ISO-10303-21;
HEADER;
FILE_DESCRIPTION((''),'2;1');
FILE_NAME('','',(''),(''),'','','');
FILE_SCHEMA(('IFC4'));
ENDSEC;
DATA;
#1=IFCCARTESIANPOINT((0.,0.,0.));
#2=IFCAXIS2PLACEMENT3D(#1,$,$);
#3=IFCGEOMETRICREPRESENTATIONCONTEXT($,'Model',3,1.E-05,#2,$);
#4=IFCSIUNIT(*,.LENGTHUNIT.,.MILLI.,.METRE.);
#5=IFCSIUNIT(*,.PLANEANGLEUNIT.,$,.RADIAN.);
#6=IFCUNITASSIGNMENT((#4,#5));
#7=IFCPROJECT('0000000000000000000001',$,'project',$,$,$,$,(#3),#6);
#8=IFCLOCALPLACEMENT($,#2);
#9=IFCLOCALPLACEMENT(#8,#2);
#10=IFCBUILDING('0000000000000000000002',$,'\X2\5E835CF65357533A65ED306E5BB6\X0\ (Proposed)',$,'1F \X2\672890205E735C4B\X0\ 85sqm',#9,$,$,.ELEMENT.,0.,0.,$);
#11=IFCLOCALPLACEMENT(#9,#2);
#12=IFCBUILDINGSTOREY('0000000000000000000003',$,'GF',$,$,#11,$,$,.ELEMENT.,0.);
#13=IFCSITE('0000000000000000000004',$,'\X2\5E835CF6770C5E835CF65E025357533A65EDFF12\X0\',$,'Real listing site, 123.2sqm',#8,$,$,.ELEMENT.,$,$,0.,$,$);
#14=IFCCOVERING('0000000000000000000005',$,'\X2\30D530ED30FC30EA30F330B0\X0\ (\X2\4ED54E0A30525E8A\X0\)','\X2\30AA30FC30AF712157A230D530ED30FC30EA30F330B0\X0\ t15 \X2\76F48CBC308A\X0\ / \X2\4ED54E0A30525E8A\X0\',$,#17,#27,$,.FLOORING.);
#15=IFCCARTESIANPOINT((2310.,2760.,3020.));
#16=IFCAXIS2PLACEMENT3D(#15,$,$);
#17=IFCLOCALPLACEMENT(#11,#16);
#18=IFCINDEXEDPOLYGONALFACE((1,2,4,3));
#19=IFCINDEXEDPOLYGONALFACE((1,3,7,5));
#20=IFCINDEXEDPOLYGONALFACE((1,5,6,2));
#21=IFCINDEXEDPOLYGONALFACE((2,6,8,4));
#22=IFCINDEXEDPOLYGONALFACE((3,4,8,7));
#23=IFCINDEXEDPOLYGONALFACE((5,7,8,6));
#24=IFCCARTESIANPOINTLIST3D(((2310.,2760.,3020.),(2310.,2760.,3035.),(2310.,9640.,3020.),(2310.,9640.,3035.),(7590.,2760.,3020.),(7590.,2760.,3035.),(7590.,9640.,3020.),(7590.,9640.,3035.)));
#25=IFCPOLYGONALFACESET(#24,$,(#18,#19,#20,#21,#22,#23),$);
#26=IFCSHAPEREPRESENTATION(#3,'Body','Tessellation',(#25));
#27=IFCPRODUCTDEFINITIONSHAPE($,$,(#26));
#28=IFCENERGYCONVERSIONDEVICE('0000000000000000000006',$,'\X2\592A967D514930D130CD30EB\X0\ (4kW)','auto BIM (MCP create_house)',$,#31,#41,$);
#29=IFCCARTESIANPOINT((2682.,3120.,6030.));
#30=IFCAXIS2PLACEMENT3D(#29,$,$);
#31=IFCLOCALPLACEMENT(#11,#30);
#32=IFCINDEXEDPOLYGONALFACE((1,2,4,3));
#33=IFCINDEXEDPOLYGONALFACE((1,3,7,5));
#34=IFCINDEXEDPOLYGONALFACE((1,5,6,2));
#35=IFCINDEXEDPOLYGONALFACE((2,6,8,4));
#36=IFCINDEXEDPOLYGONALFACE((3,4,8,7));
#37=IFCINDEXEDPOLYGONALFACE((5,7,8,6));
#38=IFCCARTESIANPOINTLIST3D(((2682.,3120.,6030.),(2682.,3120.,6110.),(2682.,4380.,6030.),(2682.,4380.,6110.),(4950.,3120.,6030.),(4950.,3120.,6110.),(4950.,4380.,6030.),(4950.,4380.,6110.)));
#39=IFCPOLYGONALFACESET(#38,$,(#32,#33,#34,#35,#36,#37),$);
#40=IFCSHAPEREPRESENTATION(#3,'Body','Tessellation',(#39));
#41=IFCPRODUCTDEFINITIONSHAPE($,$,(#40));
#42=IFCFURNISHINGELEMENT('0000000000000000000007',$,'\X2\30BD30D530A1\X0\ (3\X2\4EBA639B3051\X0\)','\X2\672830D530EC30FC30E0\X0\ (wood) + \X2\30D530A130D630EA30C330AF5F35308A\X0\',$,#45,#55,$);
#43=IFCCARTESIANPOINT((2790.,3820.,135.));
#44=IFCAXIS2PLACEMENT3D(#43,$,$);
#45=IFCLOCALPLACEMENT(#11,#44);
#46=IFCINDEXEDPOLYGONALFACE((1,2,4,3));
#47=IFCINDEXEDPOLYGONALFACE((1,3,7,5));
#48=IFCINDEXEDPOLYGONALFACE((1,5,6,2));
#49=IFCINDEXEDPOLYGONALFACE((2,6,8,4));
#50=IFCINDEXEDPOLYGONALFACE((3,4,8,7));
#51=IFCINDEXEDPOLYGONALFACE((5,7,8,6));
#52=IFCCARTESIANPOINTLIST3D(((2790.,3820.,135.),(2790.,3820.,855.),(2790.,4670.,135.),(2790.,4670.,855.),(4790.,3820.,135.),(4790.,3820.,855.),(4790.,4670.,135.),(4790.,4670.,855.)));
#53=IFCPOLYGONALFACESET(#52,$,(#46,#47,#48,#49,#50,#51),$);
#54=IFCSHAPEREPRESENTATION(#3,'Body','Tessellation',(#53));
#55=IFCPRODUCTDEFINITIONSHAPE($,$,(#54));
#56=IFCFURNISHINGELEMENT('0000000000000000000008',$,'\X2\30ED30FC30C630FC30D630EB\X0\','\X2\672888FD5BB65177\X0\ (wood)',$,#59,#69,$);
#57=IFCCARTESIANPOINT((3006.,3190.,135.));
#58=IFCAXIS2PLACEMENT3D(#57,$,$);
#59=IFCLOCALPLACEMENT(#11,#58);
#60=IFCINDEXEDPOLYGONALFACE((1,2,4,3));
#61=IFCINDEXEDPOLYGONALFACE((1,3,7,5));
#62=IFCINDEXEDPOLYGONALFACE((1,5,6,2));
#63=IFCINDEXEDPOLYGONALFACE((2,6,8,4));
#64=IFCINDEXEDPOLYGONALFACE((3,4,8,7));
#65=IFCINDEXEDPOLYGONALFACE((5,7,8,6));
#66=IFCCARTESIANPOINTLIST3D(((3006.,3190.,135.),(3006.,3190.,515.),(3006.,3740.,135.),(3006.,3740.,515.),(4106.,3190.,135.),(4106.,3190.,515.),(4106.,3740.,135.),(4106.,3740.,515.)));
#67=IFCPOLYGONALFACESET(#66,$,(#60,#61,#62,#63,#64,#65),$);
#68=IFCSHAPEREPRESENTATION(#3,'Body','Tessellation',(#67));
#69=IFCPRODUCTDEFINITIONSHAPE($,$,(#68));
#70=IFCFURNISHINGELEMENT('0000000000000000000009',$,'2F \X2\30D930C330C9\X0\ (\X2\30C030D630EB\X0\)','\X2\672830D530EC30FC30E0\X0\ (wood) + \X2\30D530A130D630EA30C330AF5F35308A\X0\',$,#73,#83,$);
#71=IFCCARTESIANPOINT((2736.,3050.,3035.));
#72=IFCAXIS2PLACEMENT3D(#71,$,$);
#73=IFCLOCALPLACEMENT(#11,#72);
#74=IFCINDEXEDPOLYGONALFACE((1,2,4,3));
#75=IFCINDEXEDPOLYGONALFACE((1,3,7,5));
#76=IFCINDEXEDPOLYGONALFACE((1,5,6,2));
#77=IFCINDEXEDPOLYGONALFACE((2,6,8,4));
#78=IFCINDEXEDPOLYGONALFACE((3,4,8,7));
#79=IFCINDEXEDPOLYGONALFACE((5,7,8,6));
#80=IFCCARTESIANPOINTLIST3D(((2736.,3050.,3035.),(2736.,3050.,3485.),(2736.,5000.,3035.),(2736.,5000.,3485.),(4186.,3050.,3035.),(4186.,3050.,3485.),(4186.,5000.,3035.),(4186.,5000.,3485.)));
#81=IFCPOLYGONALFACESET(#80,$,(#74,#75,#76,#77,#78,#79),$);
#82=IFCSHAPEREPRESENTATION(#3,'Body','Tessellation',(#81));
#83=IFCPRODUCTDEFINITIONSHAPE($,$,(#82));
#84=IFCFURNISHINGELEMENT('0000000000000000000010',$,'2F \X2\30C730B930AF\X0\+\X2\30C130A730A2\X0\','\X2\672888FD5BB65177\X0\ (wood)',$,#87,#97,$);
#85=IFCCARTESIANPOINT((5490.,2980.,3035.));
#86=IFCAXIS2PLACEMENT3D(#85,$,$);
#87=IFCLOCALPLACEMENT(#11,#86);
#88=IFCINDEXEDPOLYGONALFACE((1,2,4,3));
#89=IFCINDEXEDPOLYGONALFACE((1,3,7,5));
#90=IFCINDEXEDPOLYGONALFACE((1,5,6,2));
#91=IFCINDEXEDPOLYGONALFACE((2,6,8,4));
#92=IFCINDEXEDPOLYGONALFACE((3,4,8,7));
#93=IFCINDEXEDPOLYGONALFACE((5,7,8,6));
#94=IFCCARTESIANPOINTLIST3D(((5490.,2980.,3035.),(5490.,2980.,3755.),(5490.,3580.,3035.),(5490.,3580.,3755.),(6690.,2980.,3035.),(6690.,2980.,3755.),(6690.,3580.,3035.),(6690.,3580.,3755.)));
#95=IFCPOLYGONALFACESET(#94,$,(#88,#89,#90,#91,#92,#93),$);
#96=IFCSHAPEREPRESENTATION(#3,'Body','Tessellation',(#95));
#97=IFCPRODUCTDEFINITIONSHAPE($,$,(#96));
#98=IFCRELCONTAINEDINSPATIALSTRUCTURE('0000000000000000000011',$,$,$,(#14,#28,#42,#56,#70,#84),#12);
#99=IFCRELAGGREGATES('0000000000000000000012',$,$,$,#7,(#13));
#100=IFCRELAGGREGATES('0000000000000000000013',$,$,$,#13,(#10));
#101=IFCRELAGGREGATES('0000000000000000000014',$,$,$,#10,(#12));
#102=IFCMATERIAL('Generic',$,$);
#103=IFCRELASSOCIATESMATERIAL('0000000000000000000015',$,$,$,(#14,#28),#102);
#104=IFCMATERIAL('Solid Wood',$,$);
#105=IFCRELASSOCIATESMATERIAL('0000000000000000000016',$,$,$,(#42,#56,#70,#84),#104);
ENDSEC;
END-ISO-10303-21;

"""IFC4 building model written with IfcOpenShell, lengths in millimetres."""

from ifc_helpers import new_model, si_unit, frame, frame_2d, origin, place, context, project, spatial, rectangle, extrude, material, element, save


model = new_model("IFC4")

# Units and contexts
model_context = context("Model", 3, precision=1e-05, world=origin())
ifc_project = project(units=[si_unit("LENGTHUNIT", "METRE", prefix="MILLI"), si_unit("PLANEANGLEUNIT", "RADIAN")], contexts=[model_context])

# Site, building, storey
site_placement = place(None, origin())
site = spatial("IfcSite", under=ifc_project, at=site_placement, Name="広島県広島市南区旭２", ObjectType="Real listing site, 123.2sqm", CompositionType="ELEMENT", RefElevation=0.0)
building_placement = place(site_placement, origin())
building = spatial("IfcBuilding", under=site, at=building_placement, Name="広島南区旭の家 (Proposed)", ObjectType="1F 木造平屋 85sqm", CompositionType="ELEMENT", ElevationOfRefHeight=0.0, ElevationOfTerrain=0.0)
storey_placement = place(building_placement, origin())
storey = spatial("IfcBuildingStorey", under=building, at=storey_placement, Name="GF", CompositionType="ELEMENT", Elevation=0.0)

# Shared definitions
ifc_material_1 = material(Name="Solid Wood")

# Shared definitions
ifc_material_2 = material(Name="Generic")

# Covering
covering_placement = place(storey_placement, frame((2310.0, 2760.0, 3020.0)))
element("IfcCovering", 1, at=covering_placement, inside=storey, material=ifc_material_2, Name="フローリング (仕上げ床)", Description="オーク無垢フローリング t15 直貼り / 仕上げ床", PredefinedType="FLOORING", context=model_context, shape_type="SweptSolid", body=[
    extrude(rectangle(XDim=5280.0, YDim=6880.0, at=frame_2d((2640.0, 3440.0))), frame((2310.0, 2760.0, 3020.0)), (0.0, 0.0, 1.0), 15.0),
])

# Energy conversion device
energy_conversion_device_placement = place(storey_placement, frame((2682.0, 3120.0, 6030.0)))
element("IfcEnergyConversionDevice", 2, at=energy_conversion_device_placement, inside=storey, material=ifc_material_2, Name="太陽光パネル (4kW)", Description="auto BIM (MCP create_house)", context=model_context, shape_type="SweptSolid", body=[
    extrude(rectangle(XDim=2268.0, YDim=1260.0, at=frame_2d((1134.0, 630.0))), frame((2682.0, 3120.0, 6030.0)), (0.0, 0.0, 1.0), 80.0),
])

# Furnishing elements
furnishing_1_placement = place(storey_placement, frame((2790.0, 3820.0, 135.0)))
element("IfcFurnishingElement", 3, at=furnishing_1_placement, inside=storey, material=ifc_material_1, Name="ソファ (3人掛け)", Description="木フレーム (wood) + ファブリック張り", context=model_context, shape_type="SweptSolid", body=[
    extrude(rectangle(XDim=2000.0, YDim=850.0, at=frame_2d((1000.0, 425.0))), frame((2790.0, 3820.0, 135.0)), (0.0, 0.0, 1.0), 720.0),
])
furnishing_2_placement = place(storey_placement, frame((3006.0, 3190.0, 135.0)))
element("IfcFurnishingElement", 4, at=furnishing_2_placement, inside=storey, material=ifc_material_1, Name="ローテーブル", Description="木製家具 (wood)", context=model_context, shape_type="SweptSolid", body=[
    extrude(rectangle(XDim=1100.0, YDim=550.0, at=frame_2d((550.0, 275.0))), frame((3006.0, 3190.0, 135.0)), (0.0, 0.0, 1.0), 380.0),
])
furnishing_3_placement = place(storey_placement, frame((2736.0, 3050.0, 3035.0)))
element("IfcFurnishingElement", 5, at=furnishing_3_placement, inside=storey, material=ifc_material_1, Name="2F ベッド (ダブル)", Description="木フレーム (wood) + ファブリック張り", context=model_context, shape_type="SweptSolid", body=[
    extrude(rectangle(XDim=1450.0, YDim=1950.0, at=frame_2d((725.0, 975.0))), frame((2736.0, 3050.0, 3035.0)), (0.0, 0.0, 1.0), 450.0),
])
furnishing_4_placement = place(storey_placement, frame((5490.0, 2980.0, 3035.0)))
element("IfcFurnishingElement", 6, at=furnishing_4_placement, inside=storey, material=ifc_material_1, Name="2F デスク+チェア", Description="木製家具 (wood)", context=model_context, shape_type="SweptSolid", body=[
    extrude(rectangle(XDim=1200.0, YDim=600.0, at=frame_2d((600.0, 300.0))), frame((5490.0, 2980.0, 3035.0)), (0.0, 0.0, 1.0), 720.0),
])

save(model, "model.ifc")
